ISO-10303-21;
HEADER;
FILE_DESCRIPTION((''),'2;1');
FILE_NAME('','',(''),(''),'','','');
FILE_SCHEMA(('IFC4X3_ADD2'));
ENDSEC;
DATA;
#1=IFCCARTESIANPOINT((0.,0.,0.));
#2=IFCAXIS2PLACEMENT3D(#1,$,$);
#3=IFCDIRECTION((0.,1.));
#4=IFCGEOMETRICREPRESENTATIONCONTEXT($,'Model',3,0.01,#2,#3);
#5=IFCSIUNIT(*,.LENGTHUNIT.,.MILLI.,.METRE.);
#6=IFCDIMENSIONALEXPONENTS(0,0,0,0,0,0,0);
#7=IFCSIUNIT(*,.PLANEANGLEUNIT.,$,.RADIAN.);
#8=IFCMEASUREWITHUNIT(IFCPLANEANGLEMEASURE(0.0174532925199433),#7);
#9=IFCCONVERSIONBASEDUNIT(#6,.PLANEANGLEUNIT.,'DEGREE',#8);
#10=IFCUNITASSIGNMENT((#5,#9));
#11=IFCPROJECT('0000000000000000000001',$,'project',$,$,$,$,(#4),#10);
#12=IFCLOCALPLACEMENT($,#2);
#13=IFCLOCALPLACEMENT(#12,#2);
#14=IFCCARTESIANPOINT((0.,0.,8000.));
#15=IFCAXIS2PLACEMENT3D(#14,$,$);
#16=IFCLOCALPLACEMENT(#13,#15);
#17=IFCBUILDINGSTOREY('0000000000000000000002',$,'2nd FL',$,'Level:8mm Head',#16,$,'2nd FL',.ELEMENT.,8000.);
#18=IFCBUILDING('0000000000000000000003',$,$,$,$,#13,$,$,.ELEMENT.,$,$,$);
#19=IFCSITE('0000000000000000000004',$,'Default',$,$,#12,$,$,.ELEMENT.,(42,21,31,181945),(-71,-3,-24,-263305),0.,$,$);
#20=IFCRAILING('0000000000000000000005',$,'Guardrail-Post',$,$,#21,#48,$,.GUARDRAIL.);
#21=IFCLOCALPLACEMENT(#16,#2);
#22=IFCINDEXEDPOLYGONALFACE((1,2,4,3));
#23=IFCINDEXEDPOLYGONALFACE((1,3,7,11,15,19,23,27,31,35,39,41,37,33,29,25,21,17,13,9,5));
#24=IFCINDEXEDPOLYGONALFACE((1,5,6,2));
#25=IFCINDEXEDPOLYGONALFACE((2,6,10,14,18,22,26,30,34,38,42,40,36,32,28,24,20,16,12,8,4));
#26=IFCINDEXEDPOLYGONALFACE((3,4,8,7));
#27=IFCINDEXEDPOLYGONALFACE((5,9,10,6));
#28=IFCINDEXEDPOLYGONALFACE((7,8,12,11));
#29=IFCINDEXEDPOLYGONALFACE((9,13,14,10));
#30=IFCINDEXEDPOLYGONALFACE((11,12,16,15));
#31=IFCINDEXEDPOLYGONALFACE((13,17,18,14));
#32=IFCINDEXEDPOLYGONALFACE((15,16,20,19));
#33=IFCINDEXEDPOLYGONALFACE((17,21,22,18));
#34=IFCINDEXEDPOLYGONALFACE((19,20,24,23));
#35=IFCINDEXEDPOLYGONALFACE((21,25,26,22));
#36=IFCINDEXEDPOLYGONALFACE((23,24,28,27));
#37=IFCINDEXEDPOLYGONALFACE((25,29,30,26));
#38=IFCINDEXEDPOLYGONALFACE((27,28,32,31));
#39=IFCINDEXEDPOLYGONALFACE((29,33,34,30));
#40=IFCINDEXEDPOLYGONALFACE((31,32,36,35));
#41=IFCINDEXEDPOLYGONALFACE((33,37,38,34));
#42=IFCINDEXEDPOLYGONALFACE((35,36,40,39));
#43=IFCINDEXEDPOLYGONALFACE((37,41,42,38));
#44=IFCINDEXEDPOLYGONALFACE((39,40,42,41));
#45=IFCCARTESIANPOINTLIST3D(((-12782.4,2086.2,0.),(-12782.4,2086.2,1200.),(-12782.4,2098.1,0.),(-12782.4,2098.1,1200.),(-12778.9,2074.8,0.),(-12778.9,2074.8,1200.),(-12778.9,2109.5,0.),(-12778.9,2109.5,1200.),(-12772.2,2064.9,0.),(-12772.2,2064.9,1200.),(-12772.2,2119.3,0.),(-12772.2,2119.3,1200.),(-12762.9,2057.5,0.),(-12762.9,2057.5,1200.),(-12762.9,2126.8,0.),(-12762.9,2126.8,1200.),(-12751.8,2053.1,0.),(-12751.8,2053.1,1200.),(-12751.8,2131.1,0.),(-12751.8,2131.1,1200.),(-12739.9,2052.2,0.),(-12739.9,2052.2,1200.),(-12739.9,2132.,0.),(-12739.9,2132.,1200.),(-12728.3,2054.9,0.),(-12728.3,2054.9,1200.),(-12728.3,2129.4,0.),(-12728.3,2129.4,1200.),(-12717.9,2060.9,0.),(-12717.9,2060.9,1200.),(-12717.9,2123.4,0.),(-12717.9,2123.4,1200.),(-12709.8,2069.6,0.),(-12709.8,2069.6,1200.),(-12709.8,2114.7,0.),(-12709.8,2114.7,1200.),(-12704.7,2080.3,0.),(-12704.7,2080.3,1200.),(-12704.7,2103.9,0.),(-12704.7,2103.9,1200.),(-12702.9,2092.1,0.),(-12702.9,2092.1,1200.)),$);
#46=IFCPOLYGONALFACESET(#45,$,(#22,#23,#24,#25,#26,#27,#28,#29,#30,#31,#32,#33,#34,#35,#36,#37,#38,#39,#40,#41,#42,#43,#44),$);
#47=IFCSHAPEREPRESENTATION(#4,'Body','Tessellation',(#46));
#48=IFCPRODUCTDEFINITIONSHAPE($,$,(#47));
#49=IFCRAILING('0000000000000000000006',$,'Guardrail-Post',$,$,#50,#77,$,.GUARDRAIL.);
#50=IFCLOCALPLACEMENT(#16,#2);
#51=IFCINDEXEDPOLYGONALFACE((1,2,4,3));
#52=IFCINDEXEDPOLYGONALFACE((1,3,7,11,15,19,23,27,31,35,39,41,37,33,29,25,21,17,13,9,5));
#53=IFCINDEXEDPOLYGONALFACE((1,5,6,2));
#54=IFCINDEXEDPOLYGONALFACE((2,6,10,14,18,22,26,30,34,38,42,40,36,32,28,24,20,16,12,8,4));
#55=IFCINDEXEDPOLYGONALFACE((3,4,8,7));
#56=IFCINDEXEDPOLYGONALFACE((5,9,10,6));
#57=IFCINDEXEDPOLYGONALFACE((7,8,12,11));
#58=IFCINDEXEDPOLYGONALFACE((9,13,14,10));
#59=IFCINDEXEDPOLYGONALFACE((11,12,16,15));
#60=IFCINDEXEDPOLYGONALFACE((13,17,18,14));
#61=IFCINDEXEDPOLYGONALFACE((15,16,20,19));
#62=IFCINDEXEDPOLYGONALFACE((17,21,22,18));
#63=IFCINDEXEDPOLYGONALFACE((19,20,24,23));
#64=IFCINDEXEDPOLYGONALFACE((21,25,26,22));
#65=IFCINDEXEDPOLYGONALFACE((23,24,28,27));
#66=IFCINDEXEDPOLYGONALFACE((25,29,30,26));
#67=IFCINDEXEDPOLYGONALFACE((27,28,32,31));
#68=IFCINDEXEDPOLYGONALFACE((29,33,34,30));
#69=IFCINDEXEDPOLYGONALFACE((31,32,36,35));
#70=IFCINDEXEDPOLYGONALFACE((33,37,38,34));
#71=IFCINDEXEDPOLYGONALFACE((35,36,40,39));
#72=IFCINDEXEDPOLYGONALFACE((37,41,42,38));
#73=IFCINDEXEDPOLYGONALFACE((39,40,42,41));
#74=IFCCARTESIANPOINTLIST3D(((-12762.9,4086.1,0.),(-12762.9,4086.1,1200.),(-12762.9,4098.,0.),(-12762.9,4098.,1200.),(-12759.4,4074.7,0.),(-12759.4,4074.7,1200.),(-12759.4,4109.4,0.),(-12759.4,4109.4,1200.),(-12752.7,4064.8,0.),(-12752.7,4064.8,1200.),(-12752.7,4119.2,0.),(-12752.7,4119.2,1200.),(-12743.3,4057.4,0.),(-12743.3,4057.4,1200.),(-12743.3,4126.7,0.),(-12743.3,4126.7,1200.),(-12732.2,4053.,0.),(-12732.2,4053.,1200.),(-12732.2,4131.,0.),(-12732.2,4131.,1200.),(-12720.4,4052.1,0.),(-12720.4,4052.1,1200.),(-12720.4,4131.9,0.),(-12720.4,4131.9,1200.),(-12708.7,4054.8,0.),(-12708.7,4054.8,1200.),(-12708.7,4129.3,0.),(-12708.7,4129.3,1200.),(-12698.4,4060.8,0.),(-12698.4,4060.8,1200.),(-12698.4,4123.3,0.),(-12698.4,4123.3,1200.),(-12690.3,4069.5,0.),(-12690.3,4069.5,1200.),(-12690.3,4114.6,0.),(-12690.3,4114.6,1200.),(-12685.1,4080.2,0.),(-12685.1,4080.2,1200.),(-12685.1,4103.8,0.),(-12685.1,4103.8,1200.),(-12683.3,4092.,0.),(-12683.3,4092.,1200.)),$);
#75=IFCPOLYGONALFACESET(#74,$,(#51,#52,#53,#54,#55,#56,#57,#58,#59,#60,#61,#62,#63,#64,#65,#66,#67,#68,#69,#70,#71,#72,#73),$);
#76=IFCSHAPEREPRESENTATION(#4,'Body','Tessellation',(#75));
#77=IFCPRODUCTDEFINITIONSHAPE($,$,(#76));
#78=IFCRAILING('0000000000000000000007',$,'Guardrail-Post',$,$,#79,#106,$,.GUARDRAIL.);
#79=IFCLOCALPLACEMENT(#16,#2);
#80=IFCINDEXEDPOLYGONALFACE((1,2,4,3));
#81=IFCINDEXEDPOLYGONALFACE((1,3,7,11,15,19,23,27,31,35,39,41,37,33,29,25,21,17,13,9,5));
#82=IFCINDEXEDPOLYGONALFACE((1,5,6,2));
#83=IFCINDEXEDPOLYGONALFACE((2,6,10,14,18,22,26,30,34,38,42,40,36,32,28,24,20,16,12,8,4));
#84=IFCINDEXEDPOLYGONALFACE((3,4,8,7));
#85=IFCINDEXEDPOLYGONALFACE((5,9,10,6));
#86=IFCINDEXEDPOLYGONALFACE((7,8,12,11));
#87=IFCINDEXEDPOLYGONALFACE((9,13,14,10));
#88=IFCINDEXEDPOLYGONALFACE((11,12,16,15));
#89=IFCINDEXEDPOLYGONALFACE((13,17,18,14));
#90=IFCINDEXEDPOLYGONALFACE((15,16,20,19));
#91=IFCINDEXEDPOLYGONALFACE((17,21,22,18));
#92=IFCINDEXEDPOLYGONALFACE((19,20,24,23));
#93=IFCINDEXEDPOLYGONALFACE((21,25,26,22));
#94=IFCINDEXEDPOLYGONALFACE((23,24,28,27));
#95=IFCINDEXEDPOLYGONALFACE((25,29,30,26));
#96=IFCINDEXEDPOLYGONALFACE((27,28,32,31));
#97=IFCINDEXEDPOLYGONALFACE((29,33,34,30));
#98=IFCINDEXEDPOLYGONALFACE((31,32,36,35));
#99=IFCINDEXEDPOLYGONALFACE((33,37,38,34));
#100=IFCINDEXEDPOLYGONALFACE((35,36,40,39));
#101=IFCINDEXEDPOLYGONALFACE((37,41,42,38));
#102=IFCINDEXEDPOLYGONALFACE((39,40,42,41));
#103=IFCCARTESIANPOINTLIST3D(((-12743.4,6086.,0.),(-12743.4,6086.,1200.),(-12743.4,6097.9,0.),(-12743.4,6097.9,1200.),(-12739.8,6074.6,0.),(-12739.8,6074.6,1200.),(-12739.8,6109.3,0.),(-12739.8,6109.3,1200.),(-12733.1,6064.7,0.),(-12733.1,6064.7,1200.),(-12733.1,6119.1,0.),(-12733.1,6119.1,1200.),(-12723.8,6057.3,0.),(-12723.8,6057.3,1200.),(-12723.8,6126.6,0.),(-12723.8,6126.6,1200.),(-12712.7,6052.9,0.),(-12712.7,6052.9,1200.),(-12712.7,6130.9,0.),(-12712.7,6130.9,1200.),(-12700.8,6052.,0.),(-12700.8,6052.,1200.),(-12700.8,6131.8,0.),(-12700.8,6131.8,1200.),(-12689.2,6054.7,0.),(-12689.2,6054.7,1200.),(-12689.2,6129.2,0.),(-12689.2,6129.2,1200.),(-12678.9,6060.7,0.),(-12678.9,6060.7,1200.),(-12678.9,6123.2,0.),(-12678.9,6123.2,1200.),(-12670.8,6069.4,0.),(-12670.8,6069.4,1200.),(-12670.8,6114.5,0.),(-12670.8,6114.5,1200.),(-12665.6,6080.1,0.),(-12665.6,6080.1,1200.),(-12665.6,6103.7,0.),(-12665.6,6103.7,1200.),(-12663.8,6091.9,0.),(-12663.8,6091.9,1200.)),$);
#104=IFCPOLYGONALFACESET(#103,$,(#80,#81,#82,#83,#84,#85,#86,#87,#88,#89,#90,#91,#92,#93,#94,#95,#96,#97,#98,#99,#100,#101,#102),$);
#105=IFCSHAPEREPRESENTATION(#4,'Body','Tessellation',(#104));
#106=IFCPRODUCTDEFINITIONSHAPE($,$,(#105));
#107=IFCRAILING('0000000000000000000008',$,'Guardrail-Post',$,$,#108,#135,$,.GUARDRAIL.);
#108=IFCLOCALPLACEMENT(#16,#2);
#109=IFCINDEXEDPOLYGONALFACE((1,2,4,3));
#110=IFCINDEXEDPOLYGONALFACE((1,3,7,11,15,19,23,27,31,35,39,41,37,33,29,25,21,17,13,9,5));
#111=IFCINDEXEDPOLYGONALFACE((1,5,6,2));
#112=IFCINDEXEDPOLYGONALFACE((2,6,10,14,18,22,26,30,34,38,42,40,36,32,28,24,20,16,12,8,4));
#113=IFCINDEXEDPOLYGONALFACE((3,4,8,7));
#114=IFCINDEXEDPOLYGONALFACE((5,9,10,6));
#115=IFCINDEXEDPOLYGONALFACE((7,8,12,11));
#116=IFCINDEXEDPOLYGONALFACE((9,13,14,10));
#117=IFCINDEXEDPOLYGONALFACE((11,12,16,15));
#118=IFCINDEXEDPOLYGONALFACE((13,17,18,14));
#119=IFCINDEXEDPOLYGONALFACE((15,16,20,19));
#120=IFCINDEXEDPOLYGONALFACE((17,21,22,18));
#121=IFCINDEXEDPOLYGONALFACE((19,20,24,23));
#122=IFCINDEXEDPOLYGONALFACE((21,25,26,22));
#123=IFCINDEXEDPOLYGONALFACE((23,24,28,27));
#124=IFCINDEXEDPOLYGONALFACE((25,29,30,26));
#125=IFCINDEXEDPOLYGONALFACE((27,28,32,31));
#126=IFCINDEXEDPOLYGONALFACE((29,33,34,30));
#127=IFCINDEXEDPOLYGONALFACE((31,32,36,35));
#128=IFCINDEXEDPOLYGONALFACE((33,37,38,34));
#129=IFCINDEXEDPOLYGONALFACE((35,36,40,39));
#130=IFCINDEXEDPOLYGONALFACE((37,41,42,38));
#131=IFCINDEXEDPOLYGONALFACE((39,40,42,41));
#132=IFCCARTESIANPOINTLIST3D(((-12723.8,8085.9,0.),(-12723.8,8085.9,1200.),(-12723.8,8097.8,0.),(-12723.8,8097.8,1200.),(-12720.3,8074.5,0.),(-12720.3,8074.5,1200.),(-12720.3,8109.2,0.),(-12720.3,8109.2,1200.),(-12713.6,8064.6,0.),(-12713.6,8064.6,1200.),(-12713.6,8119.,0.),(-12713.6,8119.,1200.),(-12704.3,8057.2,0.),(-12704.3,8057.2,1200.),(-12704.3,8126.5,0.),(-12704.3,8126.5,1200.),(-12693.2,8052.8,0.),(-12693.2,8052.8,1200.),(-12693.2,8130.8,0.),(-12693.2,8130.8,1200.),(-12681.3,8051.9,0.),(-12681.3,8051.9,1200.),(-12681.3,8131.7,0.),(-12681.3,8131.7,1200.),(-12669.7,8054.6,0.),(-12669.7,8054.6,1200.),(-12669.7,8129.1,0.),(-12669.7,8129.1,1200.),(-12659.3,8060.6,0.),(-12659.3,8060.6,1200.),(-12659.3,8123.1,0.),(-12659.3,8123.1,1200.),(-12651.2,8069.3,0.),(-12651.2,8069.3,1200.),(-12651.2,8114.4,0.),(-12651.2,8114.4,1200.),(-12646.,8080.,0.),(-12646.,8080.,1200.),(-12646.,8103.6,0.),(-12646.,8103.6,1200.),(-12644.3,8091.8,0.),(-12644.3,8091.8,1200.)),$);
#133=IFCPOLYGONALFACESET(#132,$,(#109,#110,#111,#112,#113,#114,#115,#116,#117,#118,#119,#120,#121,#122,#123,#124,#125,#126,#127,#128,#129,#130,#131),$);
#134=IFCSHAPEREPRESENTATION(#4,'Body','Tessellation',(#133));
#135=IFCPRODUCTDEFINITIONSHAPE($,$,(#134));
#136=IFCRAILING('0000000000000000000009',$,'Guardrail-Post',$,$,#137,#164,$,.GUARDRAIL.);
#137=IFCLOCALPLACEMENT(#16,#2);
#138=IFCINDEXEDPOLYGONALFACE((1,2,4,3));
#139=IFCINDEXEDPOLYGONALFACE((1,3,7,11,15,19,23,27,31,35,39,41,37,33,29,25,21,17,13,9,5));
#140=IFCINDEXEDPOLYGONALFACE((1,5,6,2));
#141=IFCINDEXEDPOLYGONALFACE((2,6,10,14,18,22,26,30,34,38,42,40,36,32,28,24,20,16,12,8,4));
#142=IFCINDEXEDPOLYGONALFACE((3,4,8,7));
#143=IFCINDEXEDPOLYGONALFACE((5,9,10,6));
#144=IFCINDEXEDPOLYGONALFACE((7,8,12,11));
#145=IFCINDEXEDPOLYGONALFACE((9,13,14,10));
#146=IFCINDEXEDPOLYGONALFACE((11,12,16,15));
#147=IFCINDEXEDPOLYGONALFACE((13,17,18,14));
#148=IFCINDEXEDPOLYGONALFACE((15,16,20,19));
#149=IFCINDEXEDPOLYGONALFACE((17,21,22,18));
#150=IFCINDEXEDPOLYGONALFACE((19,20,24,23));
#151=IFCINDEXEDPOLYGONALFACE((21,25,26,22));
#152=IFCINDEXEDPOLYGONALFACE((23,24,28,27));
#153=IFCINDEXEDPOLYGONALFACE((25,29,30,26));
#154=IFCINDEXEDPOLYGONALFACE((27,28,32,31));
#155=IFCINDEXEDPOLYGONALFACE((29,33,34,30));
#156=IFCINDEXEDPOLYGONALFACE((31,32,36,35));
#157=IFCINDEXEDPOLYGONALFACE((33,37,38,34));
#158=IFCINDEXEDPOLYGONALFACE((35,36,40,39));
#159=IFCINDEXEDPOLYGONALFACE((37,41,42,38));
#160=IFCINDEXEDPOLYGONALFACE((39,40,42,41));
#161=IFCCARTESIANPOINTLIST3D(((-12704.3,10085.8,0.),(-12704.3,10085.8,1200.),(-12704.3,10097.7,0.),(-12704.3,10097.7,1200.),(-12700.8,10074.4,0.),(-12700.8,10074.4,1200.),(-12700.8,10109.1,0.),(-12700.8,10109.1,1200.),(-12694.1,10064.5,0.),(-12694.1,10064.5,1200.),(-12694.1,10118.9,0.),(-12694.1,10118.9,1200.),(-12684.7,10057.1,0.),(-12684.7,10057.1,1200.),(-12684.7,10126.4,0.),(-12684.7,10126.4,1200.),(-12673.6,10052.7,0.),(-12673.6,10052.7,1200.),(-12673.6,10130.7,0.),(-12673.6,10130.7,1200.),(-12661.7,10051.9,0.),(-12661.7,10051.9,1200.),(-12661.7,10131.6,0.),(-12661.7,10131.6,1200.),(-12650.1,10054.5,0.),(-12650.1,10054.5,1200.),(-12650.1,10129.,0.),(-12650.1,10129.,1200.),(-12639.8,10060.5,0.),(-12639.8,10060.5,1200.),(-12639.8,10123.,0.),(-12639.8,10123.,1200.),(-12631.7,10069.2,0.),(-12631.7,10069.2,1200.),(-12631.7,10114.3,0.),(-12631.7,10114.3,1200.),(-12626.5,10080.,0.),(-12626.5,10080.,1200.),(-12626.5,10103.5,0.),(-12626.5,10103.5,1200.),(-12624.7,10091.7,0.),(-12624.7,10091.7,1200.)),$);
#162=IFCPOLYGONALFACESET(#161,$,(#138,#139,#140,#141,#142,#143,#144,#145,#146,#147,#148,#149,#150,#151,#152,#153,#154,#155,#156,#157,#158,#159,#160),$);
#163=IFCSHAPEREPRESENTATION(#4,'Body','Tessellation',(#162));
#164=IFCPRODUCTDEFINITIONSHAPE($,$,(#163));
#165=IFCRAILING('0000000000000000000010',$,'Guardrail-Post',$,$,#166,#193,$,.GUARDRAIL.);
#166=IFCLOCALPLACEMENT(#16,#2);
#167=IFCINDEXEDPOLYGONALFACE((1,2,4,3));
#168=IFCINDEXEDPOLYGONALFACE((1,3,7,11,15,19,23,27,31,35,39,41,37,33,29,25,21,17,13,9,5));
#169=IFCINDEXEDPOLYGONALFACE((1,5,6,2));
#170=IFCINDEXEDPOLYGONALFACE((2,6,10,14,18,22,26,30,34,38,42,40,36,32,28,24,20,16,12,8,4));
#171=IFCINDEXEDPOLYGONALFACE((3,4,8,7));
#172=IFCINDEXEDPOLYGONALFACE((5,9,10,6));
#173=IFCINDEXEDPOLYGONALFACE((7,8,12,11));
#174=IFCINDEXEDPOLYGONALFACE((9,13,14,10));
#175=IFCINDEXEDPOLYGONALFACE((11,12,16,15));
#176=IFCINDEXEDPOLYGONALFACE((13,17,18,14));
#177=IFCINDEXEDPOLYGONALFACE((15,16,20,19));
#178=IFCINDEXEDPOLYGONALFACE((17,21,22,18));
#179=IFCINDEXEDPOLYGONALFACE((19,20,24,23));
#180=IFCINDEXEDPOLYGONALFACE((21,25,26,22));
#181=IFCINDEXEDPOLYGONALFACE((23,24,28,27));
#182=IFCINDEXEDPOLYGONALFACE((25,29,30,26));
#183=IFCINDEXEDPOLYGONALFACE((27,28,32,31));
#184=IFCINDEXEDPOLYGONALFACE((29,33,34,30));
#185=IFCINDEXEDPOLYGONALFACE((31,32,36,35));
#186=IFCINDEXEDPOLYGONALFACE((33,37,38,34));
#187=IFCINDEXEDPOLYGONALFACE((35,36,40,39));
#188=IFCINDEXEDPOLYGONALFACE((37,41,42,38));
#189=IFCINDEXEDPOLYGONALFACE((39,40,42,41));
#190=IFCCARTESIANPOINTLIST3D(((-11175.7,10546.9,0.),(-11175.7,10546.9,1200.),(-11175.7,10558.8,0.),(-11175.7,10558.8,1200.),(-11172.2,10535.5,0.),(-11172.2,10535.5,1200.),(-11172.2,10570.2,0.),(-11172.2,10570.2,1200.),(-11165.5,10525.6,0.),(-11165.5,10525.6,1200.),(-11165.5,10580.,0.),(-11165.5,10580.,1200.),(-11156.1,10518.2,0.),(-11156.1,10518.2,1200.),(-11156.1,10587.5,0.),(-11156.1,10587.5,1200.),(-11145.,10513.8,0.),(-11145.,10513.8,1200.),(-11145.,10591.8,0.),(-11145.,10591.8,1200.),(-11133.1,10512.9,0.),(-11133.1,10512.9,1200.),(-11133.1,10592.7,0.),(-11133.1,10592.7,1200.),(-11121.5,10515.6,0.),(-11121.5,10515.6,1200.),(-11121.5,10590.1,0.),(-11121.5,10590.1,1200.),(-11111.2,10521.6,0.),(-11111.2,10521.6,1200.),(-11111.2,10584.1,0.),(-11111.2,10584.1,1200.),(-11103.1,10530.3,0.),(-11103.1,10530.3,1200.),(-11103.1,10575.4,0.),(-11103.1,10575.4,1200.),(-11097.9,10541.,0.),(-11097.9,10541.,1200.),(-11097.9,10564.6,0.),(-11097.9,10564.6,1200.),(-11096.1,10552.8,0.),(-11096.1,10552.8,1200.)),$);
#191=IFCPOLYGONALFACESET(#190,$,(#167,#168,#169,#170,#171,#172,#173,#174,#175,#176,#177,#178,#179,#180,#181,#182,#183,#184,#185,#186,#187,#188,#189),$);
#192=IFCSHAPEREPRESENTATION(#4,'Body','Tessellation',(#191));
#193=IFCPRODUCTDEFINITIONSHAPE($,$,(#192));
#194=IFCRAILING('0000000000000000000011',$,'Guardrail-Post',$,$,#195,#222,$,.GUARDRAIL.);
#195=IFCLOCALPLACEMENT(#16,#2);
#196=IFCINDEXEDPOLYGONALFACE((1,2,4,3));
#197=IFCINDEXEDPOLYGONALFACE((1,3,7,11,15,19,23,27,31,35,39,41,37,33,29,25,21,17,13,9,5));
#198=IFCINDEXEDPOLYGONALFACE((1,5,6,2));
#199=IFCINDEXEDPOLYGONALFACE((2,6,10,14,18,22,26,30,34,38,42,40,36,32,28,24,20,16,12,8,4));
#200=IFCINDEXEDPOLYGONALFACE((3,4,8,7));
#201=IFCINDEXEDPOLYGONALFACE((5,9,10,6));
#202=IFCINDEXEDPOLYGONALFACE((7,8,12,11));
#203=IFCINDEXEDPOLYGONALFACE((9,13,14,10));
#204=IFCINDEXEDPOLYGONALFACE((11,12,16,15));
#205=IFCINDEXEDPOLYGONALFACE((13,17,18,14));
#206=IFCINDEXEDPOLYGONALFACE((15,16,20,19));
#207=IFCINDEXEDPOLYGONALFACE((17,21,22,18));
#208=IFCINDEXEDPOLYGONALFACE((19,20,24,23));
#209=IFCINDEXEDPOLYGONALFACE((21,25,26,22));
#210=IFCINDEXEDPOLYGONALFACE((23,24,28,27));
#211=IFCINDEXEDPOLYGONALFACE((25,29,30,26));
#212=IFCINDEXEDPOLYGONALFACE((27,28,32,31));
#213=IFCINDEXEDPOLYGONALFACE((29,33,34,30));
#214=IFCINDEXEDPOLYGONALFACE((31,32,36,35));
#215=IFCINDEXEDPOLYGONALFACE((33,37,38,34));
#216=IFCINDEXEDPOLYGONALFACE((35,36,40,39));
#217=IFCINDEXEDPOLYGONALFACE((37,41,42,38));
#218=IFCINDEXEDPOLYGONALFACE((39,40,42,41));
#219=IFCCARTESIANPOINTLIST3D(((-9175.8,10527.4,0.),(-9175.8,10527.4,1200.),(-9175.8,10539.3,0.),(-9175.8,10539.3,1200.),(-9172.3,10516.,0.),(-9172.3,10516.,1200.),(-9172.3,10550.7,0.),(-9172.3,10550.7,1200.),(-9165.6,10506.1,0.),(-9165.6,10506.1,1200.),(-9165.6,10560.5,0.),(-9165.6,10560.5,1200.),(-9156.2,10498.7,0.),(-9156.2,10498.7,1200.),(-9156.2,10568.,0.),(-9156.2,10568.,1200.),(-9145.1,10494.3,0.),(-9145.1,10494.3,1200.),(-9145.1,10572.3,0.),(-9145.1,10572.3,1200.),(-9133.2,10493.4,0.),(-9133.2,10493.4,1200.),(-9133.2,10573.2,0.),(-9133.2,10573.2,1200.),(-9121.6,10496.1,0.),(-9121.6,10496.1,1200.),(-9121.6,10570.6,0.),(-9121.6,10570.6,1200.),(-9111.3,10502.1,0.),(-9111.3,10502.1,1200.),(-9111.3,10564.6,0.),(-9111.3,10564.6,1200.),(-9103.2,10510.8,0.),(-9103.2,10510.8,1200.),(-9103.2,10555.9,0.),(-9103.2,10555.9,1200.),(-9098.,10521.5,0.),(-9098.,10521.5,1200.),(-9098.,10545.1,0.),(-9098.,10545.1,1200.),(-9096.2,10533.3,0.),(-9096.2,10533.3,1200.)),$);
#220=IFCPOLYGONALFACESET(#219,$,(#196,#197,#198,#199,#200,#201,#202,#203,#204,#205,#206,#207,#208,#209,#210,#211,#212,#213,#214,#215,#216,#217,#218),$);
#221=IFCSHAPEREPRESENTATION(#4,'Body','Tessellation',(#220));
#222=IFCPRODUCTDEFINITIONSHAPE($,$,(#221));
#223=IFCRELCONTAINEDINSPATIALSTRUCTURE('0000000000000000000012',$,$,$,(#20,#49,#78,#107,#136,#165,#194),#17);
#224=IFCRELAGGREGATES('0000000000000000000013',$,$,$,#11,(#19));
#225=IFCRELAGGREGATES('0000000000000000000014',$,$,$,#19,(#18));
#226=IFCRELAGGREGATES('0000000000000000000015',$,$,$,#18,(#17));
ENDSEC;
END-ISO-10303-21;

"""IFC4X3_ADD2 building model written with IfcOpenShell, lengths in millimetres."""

from ifc_helpers import new_model, entity, si_unit, converted_unit, direction, frame, origin, origin_with_axes, origin_2d, place, context, project, spatial, circle, extrude, element, save


model = new_model("IFC4X3_ADD2")

# Units and contexts
model_context = context("Model", 3, precision=0.01, world=origin(), true_north=direction((0.0, 1.0)))
ifc_project = project(units=[si_unit("LENGTHUNIT", "METRE", prefix="MILLI"), converted_unit("PLANEANGLEUNIT", "DEGREE", entity("IfcPlaneAngleMeasure", 0.0174532925199433), si_unit("PLANEANGLEUNIT", "RADIAN"), dimensions=[0, 0, 0, 0, 0, 0, 0])], contexts=[model_context])

# Site, building, storey
site_placement = place(None, origin())
site = spatial("IfcSite", under=ifc_project, at=site_placement, Name="Default", CompositionType="ELEMENT", RefLatitude=(42, 21, 31, 181945), RefLongitude=(-71, -3, -24, -263305), RefElevation=0.0)
building_placement = place(site_placement, origin())
building = spatial("IfcBuilding", under=site, at=building_placement, CompositionType="ELEMENT")
storey_placement = place(building_placement, frame((0.0, 0.0, 8000.0)))
storey = spatial("IfcBuildingStorey", under=building, at=storey_placement, Name="2nd FL", ObjectType="Level:8mm Head", LongName="2nd FL", CompositionType="ELEMENT", Elevation=8000.0)

# Railings
for number, where, z_axis, x_axis, name in (
    (1, (-12742.9, 2092.1, 8000.0), (0.0, 0.0, 1.0), (1.0, 0.0, 0.0), "Guardrail-Post"),
    (2, (-12723.3, 4092.0, 8000.0), (0.0, 0.0, 1.0), (1.0, 0.0, 0.0), "Guardrail-Post"),
    (3, (-12703.8, 6091.9, 8000.0), (0.0, 0.0, 1.0), (1.0, 0.0, 0.0), "Guardrail-Post"),
    (4, (-12684.3, 8091.8, 8000.0), (0.0, 0.0, 1.0), (1.0, 0.0, 0.0), "Guardrail-Post"),
    (5, (-12664.7, 10091.7, 8000.0), (0.0, 0.0, 1.0), (1.0, 0.0, 0.0), "Guardrail-Post"),
    (6, (-11136.1, 10552.8, 8000.0), (0.0, 0.0, 1.0), (1.0, 0.0, 0.0), "Guardrail-Post"),
    (7, (-9136.2, 10533.3, 8000.0), (0.0, 0.0, 1.0), (1.0, 0.0, 0.0), "Guardrail-Post"),
):
    element("IfcRailing", number, at=place(None, frame(where, z_axis=z_axis, x_axis=x_axis)), inside=storey, Name=name, PredefinedType="GUARDRAIL", context=model_context, shape_type="SweptSolid", body=[
        extrude(circle(Radius=40.0, at=origin_2d()), origin_with_axes(), (0.0, 0.0, 1.0), 1200.0),
    ])

save(model, "model.ifc")
